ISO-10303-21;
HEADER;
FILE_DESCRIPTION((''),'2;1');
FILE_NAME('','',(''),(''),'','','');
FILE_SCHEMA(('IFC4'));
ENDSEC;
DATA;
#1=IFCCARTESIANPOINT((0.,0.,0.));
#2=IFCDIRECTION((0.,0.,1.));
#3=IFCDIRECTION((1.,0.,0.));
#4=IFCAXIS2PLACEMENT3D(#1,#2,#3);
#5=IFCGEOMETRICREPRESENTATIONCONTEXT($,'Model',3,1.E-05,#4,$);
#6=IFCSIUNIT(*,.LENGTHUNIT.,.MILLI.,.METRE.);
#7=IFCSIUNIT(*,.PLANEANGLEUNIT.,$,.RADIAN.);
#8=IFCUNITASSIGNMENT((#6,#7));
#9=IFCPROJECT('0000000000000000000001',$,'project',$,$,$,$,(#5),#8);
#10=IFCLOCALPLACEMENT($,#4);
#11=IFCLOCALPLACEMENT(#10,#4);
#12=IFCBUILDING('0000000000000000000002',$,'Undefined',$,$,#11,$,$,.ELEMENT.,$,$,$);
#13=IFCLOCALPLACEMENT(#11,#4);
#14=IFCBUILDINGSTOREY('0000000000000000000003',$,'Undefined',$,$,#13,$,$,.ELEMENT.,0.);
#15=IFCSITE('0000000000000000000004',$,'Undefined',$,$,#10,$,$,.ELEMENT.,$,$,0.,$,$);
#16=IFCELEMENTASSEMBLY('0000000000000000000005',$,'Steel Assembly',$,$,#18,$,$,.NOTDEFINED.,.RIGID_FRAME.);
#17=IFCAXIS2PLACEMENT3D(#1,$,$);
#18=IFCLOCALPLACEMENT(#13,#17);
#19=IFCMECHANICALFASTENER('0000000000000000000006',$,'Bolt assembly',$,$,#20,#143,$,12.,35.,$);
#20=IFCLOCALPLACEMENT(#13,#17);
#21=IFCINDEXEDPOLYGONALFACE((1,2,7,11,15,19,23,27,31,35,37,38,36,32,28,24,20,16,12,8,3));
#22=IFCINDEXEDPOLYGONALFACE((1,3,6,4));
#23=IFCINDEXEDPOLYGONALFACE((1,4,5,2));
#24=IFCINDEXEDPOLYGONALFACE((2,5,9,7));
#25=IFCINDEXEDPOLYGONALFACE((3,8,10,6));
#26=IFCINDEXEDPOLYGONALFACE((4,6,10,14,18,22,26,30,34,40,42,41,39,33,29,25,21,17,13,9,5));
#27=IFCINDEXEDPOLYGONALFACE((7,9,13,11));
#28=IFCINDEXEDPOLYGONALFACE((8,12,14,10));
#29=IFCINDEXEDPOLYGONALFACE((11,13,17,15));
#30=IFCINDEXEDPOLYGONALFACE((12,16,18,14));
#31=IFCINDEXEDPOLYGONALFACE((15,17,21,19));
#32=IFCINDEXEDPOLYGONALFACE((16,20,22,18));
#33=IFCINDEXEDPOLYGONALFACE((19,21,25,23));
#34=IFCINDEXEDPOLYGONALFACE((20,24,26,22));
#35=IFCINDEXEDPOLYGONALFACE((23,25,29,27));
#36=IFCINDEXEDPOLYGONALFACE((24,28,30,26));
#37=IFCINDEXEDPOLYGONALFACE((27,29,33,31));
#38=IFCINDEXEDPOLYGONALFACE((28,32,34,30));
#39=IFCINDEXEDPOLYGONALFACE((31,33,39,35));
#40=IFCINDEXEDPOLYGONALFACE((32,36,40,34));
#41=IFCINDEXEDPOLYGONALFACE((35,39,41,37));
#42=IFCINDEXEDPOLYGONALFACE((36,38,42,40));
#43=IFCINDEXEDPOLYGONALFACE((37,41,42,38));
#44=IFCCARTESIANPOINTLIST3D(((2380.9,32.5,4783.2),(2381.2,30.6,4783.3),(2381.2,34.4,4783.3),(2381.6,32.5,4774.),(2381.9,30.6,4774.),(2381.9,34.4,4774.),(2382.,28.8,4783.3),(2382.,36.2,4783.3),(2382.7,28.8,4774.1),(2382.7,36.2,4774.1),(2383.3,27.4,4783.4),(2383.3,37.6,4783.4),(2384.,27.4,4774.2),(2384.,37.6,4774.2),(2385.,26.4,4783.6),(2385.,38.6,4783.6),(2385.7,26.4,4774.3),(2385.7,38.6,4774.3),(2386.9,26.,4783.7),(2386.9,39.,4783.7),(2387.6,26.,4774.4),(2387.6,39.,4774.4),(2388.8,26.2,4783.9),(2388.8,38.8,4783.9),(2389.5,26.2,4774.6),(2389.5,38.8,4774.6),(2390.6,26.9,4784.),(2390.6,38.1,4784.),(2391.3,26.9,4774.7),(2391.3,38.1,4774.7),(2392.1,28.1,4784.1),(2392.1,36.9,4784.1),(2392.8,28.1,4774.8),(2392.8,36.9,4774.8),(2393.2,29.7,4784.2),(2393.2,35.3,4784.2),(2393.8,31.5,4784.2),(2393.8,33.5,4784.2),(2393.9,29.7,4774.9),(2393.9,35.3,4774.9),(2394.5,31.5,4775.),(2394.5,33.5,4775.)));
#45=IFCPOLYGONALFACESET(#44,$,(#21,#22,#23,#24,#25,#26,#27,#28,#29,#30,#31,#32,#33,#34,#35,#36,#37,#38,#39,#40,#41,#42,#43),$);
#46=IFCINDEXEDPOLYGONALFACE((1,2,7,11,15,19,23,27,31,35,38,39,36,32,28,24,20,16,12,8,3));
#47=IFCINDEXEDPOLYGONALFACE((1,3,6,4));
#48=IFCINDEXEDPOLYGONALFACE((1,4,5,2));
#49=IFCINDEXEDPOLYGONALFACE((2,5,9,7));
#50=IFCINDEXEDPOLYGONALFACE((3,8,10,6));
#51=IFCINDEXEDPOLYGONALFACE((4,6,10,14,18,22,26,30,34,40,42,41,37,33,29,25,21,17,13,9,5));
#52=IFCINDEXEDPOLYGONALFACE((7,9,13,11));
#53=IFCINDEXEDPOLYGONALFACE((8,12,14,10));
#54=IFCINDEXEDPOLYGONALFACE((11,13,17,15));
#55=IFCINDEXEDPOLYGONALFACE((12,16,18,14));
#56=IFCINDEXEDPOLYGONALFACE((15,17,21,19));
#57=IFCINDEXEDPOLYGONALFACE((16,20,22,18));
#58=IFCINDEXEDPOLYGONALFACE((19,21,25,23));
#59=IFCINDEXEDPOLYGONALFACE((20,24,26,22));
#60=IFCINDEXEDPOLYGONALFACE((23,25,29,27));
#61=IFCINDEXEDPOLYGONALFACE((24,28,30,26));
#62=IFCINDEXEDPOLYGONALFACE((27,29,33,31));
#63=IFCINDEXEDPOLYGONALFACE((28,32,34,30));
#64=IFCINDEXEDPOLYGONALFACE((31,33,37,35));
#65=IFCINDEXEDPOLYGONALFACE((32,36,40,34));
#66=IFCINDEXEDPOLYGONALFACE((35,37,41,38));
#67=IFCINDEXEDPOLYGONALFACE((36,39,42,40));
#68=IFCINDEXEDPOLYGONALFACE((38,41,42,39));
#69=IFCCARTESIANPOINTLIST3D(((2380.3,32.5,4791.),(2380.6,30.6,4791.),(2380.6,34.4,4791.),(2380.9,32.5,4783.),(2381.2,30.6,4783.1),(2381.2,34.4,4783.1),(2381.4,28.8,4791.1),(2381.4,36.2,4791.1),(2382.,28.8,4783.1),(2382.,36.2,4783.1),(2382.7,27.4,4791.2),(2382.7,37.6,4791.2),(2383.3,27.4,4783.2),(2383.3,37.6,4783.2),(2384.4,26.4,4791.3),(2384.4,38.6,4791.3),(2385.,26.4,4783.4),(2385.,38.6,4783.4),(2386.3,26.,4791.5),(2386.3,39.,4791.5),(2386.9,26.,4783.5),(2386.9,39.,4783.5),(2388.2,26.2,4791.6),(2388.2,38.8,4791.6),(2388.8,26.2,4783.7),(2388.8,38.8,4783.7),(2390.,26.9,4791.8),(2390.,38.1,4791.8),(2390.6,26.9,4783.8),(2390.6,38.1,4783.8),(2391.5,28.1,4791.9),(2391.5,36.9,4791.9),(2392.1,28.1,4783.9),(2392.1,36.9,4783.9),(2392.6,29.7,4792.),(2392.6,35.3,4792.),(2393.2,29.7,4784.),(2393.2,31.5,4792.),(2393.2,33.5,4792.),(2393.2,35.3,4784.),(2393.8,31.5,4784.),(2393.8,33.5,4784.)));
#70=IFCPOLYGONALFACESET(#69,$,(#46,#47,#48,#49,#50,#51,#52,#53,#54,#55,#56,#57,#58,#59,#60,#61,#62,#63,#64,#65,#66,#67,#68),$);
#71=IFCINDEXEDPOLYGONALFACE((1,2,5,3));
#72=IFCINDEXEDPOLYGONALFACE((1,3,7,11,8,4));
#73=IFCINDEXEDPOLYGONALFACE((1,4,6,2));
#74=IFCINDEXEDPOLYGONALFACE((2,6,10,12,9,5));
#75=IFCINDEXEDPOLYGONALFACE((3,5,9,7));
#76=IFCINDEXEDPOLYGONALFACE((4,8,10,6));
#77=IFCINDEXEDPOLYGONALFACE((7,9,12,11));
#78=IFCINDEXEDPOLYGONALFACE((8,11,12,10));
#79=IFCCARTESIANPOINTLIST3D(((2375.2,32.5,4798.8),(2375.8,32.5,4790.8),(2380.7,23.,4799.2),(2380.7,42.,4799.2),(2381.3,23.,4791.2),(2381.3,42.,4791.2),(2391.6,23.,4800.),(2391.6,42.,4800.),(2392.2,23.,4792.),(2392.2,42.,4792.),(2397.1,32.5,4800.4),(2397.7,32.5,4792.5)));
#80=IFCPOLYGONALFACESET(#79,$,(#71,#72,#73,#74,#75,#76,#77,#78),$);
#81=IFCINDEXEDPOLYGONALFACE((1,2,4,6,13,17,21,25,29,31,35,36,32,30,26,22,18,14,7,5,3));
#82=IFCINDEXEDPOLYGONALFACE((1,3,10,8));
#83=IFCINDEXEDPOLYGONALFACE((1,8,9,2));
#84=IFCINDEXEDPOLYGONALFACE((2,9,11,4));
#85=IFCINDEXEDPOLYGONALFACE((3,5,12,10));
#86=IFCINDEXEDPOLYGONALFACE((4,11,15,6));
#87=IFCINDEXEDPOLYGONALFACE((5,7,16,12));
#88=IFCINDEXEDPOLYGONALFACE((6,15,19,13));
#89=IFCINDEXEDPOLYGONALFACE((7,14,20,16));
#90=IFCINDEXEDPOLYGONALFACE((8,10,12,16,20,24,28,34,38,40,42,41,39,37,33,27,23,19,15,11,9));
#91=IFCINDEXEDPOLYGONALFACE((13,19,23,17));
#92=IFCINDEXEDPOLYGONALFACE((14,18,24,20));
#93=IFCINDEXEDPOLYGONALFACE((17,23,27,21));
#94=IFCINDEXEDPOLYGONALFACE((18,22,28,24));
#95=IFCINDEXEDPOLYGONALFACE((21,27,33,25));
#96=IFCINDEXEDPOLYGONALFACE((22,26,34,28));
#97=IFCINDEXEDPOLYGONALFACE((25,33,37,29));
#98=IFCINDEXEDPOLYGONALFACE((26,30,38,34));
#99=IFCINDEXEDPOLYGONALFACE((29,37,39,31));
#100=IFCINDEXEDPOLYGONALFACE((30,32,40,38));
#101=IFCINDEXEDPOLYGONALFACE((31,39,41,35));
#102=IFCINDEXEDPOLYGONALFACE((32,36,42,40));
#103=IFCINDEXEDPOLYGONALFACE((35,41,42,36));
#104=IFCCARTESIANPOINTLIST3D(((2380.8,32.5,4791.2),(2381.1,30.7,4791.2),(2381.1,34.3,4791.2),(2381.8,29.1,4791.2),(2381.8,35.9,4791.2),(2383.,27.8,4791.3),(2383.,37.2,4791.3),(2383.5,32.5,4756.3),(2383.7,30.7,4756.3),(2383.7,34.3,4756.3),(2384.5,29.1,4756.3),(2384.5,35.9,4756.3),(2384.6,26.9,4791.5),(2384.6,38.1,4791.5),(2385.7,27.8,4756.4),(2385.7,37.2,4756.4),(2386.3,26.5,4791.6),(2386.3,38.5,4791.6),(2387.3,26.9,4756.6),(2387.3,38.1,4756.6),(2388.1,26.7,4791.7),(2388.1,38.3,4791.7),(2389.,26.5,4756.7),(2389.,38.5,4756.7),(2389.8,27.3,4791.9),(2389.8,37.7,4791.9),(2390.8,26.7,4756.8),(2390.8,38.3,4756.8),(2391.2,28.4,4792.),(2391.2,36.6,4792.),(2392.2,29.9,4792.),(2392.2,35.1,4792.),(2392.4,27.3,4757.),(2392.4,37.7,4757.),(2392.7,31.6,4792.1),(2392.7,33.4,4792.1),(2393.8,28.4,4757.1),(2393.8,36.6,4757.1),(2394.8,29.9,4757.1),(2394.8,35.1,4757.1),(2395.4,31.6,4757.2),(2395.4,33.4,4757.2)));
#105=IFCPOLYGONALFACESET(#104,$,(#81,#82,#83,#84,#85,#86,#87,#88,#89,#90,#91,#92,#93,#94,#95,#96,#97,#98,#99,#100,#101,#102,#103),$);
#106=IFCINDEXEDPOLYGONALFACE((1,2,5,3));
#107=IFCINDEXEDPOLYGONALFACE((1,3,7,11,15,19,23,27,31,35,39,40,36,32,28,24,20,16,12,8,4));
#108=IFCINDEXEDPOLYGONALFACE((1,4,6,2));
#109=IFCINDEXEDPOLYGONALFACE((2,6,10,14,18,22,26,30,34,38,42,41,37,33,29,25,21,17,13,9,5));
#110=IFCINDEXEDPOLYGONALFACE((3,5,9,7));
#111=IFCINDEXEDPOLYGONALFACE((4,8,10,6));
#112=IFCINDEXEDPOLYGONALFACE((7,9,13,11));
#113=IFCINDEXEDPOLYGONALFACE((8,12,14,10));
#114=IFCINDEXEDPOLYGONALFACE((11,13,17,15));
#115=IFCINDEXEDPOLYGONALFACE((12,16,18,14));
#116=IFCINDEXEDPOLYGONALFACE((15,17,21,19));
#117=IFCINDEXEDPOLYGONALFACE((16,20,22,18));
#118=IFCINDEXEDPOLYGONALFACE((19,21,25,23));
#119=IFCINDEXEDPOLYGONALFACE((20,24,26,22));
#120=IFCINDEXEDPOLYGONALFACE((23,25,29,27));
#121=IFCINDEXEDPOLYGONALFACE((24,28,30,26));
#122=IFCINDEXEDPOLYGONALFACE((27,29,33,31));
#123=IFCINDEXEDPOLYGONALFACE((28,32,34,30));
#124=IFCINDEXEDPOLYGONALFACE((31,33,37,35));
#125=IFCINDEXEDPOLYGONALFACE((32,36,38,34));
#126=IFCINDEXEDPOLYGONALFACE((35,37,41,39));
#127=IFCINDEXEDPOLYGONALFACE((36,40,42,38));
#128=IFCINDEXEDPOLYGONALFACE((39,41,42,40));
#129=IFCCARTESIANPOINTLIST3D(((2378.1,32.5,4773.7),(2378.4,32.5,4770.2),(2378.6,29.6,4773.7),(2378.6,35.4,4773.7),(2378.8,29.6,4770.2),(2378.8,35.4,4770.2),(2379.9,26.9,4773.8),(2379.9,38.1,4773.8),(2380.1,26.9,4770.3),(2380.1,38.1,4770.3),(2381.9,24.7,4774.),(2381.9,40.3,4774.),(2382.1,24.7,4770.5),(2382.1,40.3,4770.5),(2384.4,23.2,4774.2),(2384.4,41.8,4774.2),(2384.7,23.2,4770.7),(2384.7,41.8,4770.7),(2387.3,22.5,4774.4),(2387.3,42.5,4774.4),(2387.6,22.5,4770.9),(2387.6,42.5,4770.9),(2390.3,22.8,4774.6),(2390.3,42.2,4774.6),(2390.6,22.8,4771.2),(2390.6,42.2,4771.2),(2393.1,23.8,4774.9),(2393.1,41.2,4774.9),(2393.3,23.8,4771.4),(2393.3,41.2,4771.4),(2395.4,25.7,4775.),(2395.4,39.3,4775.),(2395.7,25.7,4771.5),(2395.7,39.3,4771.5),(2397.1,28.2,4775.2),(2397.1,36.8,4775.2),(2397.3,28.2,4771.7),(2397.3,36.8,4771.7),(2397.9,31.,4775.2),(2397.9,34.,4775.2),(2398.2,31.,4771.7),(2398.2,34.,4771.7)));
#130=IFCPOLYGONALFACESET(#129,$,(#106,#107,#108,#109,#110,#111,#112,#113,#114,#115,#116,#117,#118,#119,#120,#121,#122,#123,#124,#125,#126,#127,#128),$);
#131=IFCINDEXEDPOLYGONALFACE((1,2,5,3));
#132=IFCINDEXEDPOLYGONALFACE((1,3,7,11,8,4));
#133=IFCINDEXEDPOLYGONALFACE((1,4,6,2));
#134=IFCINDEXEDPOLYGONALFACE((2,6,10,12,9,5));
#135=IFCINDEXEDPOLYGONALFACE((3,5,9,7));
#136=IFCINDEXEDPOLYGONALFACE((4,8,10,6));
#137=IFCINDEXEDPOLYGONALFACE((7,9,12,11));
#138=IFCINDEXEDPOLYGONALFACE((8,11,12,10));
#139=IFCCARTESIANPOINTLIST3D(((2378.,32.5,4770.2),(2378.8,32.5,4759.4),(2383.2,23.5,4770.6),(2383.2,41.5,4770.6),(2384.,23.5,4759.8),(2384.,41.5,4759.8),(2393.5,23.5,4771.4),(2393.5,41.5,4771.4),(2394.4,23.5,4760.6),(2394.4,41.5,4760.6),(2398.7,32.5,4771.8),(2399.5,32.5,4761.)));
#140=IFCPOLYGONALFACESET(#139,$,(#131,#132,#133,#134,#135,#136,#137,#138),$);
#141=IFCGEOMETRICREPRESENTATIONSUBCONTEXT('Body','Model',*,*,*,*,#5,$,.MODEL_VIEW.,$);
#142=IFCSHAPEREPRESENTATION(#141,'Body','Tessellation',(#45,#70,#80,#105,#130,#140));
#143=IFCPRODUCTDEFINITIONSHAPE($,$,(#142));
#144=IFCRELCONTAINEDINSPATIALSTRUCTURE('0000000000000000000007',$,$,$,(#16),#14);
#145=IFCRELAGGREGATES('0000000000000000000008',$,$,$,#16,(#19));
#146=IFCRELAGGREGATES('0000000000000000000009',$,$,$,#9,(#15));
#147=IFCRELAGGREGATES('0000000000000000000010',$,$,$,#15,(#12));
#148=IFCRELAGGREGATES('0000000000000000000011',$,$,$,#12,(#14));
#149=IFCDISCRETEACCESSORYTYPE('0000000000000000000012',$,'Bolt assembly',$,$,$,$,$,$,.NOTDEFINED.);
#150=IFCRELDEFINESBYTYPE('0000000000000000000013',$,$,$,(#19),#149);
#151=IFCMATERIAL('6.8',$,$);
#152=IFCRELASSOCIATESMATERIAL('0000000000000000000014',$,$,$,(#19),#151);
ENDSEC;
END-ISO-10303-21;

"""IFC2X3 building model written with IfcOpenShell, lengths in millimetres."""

from ifc_helpers import new_model, si_unit, frame, origin_with_axes, origin_2d_with_axis, place, context, subcontext, project, spatial, polyline, circle, outline, extrude, source, transform, mapped, material, type_object, element, aggregate, save


model = new_model("IFC2X3")

# Units and contexts
model_context = context("Model", 3, precision=1e-05, world=origin_with_axes())
body_context = subcontext(model_context, "Body", "Model", "MODEL_VIEW")
ifc_project = project(units=[si_unit("LENGTHUNIT", "METRE", prefix="MILLI"), si_unit("PLANEANGLEUNIT", "RADIAN")], contexts=[model_context])

# Site, building, storey
site_placement = place(None, origin_with_axes())
site = spatial("IfcSite", under=ifc_project, at=site_placement, Name="Undefined", CompositionType="ELEMENT", RefElevation=0.0)
building_placement = place(site_placement, origin_with_axes())
building = spatial("IfcBuilding", under=site, at=building_placement, Name="Undefined", CompositionType="ELEMENT")
storey_placement = place(building_placement, origin_with_axes())
storey = spatial("IfcBuildingStorey", under=building, at=storey_placement, Name="Undefined", CompositionType="ELEMENT", Elevation=0.0)

# Element assembly, mechanical fastener
ifc_material_1 = material(Name="6.8")
discrete_accessory_type_1 = type_object("IfcDiscreteAccessoryType", Name="Bolt assembly")
shared_shape_1 = source(origin_with_axes(), body_context, "Body", "SweptSolid", [
    extrude(circle(Radius=6.5, at=origin_2d_with_axis()), frame((0.0, -0.1, 0.0), z_axis=(0.0, 1.0, 0.0), x_axis=(1.0, 0.0, 0.0)), (0.0, 0.0, 1.0), 9.3),
    extrude(circle(Radius=6.5, at=origin_2d_with_axis()), frame((0.0, -7.9, 0.0), z_axis=(0.0, 1.0, 0.0), x_axis=(1.0, 0.0, 0.0)), (0.0, 0.0, 1.0), 8.0),
    extrude(outline(polyline([(11.0, 0.0), (5.5, 9.5), (-5.5, 9.5), (-11.0, 0.0), (-5.5, -9.5), (5.5, -9.5), (11.0, 0.0)])), frame((0.0, -16.0, 0.0), z_axis=(0.0, 1.0, 0.0), x_axis=(1.0, 0.0, 0.0)), (0.0, 0.0, 1.0), 8.0),
    extrude(circle(Radius=6.0, at=origin_2d_with_axis()), frame((0.0, -8.0, 0.0), z_axis=(0.0, 1.0, 0.0), x_axis=(1.0, 0.0, 0.0)), (0.0, 0.0, 1.0), 35.0),
    extrude(circle(Radius=10.0, at=origin_2d_with_axis()), frame((0.0, 9.2, 0.0), z_axis=(0.0, 1.0, 0.0), x_axis=(1.0, 0.0, 0.0)), (0.0, 0.0, 1.0), 3.5),
    extrude(outline(polyline([(10.4, 0.0), (5.2, 9.0), (-5.2, 9.0), (-10.4, 0.0), (-5.2, -9.0), (5.2, -9.0), (10.4, 0.0)])), frame((0.0, 12.7, 0.0), z_axis=(0.0, 1.0, 0.0), x_axis=(1.0, 0.0, 0.0)), (0.0, 0.0, 1.0), 10.8),
])
assembly_1_placement = place(storey_placement, origin_with_axes())
assembly_1 = element("IfcElementAssembly", 1, at=assembly_1_placement, inside=storey, Name="Steel Assembly", AssemblyPlace="NOTDEFINED", PredefinedType="RIGID_FRAME")
mechanical_fastener_1_placement = place(assembly_1_placement, frame((2387.4, 32.5, 4783.6), z_axis=(0.0, -1.0, 0.0), x_axis=(-0.997054, 0.0, -0.076696)))
mechanical_fastener_1 = element("IfcMechanicalFastener", 2, at=mechanical_fastener_1_placement, type_object=discrete_accessory_type_1, material=ifc_material_1, Name="Bolt assembly", NominalDiameter=12.0, NominalLength=35.0, context=body_context, shape_type="MappedRepresentation", body=[
    mapped(shared_shape_1, transform((0.0, 0.0, 0.0))),
])
aggregate(assembly_1, [mechanical_fastener_1])

save(model, "model.ifc")
